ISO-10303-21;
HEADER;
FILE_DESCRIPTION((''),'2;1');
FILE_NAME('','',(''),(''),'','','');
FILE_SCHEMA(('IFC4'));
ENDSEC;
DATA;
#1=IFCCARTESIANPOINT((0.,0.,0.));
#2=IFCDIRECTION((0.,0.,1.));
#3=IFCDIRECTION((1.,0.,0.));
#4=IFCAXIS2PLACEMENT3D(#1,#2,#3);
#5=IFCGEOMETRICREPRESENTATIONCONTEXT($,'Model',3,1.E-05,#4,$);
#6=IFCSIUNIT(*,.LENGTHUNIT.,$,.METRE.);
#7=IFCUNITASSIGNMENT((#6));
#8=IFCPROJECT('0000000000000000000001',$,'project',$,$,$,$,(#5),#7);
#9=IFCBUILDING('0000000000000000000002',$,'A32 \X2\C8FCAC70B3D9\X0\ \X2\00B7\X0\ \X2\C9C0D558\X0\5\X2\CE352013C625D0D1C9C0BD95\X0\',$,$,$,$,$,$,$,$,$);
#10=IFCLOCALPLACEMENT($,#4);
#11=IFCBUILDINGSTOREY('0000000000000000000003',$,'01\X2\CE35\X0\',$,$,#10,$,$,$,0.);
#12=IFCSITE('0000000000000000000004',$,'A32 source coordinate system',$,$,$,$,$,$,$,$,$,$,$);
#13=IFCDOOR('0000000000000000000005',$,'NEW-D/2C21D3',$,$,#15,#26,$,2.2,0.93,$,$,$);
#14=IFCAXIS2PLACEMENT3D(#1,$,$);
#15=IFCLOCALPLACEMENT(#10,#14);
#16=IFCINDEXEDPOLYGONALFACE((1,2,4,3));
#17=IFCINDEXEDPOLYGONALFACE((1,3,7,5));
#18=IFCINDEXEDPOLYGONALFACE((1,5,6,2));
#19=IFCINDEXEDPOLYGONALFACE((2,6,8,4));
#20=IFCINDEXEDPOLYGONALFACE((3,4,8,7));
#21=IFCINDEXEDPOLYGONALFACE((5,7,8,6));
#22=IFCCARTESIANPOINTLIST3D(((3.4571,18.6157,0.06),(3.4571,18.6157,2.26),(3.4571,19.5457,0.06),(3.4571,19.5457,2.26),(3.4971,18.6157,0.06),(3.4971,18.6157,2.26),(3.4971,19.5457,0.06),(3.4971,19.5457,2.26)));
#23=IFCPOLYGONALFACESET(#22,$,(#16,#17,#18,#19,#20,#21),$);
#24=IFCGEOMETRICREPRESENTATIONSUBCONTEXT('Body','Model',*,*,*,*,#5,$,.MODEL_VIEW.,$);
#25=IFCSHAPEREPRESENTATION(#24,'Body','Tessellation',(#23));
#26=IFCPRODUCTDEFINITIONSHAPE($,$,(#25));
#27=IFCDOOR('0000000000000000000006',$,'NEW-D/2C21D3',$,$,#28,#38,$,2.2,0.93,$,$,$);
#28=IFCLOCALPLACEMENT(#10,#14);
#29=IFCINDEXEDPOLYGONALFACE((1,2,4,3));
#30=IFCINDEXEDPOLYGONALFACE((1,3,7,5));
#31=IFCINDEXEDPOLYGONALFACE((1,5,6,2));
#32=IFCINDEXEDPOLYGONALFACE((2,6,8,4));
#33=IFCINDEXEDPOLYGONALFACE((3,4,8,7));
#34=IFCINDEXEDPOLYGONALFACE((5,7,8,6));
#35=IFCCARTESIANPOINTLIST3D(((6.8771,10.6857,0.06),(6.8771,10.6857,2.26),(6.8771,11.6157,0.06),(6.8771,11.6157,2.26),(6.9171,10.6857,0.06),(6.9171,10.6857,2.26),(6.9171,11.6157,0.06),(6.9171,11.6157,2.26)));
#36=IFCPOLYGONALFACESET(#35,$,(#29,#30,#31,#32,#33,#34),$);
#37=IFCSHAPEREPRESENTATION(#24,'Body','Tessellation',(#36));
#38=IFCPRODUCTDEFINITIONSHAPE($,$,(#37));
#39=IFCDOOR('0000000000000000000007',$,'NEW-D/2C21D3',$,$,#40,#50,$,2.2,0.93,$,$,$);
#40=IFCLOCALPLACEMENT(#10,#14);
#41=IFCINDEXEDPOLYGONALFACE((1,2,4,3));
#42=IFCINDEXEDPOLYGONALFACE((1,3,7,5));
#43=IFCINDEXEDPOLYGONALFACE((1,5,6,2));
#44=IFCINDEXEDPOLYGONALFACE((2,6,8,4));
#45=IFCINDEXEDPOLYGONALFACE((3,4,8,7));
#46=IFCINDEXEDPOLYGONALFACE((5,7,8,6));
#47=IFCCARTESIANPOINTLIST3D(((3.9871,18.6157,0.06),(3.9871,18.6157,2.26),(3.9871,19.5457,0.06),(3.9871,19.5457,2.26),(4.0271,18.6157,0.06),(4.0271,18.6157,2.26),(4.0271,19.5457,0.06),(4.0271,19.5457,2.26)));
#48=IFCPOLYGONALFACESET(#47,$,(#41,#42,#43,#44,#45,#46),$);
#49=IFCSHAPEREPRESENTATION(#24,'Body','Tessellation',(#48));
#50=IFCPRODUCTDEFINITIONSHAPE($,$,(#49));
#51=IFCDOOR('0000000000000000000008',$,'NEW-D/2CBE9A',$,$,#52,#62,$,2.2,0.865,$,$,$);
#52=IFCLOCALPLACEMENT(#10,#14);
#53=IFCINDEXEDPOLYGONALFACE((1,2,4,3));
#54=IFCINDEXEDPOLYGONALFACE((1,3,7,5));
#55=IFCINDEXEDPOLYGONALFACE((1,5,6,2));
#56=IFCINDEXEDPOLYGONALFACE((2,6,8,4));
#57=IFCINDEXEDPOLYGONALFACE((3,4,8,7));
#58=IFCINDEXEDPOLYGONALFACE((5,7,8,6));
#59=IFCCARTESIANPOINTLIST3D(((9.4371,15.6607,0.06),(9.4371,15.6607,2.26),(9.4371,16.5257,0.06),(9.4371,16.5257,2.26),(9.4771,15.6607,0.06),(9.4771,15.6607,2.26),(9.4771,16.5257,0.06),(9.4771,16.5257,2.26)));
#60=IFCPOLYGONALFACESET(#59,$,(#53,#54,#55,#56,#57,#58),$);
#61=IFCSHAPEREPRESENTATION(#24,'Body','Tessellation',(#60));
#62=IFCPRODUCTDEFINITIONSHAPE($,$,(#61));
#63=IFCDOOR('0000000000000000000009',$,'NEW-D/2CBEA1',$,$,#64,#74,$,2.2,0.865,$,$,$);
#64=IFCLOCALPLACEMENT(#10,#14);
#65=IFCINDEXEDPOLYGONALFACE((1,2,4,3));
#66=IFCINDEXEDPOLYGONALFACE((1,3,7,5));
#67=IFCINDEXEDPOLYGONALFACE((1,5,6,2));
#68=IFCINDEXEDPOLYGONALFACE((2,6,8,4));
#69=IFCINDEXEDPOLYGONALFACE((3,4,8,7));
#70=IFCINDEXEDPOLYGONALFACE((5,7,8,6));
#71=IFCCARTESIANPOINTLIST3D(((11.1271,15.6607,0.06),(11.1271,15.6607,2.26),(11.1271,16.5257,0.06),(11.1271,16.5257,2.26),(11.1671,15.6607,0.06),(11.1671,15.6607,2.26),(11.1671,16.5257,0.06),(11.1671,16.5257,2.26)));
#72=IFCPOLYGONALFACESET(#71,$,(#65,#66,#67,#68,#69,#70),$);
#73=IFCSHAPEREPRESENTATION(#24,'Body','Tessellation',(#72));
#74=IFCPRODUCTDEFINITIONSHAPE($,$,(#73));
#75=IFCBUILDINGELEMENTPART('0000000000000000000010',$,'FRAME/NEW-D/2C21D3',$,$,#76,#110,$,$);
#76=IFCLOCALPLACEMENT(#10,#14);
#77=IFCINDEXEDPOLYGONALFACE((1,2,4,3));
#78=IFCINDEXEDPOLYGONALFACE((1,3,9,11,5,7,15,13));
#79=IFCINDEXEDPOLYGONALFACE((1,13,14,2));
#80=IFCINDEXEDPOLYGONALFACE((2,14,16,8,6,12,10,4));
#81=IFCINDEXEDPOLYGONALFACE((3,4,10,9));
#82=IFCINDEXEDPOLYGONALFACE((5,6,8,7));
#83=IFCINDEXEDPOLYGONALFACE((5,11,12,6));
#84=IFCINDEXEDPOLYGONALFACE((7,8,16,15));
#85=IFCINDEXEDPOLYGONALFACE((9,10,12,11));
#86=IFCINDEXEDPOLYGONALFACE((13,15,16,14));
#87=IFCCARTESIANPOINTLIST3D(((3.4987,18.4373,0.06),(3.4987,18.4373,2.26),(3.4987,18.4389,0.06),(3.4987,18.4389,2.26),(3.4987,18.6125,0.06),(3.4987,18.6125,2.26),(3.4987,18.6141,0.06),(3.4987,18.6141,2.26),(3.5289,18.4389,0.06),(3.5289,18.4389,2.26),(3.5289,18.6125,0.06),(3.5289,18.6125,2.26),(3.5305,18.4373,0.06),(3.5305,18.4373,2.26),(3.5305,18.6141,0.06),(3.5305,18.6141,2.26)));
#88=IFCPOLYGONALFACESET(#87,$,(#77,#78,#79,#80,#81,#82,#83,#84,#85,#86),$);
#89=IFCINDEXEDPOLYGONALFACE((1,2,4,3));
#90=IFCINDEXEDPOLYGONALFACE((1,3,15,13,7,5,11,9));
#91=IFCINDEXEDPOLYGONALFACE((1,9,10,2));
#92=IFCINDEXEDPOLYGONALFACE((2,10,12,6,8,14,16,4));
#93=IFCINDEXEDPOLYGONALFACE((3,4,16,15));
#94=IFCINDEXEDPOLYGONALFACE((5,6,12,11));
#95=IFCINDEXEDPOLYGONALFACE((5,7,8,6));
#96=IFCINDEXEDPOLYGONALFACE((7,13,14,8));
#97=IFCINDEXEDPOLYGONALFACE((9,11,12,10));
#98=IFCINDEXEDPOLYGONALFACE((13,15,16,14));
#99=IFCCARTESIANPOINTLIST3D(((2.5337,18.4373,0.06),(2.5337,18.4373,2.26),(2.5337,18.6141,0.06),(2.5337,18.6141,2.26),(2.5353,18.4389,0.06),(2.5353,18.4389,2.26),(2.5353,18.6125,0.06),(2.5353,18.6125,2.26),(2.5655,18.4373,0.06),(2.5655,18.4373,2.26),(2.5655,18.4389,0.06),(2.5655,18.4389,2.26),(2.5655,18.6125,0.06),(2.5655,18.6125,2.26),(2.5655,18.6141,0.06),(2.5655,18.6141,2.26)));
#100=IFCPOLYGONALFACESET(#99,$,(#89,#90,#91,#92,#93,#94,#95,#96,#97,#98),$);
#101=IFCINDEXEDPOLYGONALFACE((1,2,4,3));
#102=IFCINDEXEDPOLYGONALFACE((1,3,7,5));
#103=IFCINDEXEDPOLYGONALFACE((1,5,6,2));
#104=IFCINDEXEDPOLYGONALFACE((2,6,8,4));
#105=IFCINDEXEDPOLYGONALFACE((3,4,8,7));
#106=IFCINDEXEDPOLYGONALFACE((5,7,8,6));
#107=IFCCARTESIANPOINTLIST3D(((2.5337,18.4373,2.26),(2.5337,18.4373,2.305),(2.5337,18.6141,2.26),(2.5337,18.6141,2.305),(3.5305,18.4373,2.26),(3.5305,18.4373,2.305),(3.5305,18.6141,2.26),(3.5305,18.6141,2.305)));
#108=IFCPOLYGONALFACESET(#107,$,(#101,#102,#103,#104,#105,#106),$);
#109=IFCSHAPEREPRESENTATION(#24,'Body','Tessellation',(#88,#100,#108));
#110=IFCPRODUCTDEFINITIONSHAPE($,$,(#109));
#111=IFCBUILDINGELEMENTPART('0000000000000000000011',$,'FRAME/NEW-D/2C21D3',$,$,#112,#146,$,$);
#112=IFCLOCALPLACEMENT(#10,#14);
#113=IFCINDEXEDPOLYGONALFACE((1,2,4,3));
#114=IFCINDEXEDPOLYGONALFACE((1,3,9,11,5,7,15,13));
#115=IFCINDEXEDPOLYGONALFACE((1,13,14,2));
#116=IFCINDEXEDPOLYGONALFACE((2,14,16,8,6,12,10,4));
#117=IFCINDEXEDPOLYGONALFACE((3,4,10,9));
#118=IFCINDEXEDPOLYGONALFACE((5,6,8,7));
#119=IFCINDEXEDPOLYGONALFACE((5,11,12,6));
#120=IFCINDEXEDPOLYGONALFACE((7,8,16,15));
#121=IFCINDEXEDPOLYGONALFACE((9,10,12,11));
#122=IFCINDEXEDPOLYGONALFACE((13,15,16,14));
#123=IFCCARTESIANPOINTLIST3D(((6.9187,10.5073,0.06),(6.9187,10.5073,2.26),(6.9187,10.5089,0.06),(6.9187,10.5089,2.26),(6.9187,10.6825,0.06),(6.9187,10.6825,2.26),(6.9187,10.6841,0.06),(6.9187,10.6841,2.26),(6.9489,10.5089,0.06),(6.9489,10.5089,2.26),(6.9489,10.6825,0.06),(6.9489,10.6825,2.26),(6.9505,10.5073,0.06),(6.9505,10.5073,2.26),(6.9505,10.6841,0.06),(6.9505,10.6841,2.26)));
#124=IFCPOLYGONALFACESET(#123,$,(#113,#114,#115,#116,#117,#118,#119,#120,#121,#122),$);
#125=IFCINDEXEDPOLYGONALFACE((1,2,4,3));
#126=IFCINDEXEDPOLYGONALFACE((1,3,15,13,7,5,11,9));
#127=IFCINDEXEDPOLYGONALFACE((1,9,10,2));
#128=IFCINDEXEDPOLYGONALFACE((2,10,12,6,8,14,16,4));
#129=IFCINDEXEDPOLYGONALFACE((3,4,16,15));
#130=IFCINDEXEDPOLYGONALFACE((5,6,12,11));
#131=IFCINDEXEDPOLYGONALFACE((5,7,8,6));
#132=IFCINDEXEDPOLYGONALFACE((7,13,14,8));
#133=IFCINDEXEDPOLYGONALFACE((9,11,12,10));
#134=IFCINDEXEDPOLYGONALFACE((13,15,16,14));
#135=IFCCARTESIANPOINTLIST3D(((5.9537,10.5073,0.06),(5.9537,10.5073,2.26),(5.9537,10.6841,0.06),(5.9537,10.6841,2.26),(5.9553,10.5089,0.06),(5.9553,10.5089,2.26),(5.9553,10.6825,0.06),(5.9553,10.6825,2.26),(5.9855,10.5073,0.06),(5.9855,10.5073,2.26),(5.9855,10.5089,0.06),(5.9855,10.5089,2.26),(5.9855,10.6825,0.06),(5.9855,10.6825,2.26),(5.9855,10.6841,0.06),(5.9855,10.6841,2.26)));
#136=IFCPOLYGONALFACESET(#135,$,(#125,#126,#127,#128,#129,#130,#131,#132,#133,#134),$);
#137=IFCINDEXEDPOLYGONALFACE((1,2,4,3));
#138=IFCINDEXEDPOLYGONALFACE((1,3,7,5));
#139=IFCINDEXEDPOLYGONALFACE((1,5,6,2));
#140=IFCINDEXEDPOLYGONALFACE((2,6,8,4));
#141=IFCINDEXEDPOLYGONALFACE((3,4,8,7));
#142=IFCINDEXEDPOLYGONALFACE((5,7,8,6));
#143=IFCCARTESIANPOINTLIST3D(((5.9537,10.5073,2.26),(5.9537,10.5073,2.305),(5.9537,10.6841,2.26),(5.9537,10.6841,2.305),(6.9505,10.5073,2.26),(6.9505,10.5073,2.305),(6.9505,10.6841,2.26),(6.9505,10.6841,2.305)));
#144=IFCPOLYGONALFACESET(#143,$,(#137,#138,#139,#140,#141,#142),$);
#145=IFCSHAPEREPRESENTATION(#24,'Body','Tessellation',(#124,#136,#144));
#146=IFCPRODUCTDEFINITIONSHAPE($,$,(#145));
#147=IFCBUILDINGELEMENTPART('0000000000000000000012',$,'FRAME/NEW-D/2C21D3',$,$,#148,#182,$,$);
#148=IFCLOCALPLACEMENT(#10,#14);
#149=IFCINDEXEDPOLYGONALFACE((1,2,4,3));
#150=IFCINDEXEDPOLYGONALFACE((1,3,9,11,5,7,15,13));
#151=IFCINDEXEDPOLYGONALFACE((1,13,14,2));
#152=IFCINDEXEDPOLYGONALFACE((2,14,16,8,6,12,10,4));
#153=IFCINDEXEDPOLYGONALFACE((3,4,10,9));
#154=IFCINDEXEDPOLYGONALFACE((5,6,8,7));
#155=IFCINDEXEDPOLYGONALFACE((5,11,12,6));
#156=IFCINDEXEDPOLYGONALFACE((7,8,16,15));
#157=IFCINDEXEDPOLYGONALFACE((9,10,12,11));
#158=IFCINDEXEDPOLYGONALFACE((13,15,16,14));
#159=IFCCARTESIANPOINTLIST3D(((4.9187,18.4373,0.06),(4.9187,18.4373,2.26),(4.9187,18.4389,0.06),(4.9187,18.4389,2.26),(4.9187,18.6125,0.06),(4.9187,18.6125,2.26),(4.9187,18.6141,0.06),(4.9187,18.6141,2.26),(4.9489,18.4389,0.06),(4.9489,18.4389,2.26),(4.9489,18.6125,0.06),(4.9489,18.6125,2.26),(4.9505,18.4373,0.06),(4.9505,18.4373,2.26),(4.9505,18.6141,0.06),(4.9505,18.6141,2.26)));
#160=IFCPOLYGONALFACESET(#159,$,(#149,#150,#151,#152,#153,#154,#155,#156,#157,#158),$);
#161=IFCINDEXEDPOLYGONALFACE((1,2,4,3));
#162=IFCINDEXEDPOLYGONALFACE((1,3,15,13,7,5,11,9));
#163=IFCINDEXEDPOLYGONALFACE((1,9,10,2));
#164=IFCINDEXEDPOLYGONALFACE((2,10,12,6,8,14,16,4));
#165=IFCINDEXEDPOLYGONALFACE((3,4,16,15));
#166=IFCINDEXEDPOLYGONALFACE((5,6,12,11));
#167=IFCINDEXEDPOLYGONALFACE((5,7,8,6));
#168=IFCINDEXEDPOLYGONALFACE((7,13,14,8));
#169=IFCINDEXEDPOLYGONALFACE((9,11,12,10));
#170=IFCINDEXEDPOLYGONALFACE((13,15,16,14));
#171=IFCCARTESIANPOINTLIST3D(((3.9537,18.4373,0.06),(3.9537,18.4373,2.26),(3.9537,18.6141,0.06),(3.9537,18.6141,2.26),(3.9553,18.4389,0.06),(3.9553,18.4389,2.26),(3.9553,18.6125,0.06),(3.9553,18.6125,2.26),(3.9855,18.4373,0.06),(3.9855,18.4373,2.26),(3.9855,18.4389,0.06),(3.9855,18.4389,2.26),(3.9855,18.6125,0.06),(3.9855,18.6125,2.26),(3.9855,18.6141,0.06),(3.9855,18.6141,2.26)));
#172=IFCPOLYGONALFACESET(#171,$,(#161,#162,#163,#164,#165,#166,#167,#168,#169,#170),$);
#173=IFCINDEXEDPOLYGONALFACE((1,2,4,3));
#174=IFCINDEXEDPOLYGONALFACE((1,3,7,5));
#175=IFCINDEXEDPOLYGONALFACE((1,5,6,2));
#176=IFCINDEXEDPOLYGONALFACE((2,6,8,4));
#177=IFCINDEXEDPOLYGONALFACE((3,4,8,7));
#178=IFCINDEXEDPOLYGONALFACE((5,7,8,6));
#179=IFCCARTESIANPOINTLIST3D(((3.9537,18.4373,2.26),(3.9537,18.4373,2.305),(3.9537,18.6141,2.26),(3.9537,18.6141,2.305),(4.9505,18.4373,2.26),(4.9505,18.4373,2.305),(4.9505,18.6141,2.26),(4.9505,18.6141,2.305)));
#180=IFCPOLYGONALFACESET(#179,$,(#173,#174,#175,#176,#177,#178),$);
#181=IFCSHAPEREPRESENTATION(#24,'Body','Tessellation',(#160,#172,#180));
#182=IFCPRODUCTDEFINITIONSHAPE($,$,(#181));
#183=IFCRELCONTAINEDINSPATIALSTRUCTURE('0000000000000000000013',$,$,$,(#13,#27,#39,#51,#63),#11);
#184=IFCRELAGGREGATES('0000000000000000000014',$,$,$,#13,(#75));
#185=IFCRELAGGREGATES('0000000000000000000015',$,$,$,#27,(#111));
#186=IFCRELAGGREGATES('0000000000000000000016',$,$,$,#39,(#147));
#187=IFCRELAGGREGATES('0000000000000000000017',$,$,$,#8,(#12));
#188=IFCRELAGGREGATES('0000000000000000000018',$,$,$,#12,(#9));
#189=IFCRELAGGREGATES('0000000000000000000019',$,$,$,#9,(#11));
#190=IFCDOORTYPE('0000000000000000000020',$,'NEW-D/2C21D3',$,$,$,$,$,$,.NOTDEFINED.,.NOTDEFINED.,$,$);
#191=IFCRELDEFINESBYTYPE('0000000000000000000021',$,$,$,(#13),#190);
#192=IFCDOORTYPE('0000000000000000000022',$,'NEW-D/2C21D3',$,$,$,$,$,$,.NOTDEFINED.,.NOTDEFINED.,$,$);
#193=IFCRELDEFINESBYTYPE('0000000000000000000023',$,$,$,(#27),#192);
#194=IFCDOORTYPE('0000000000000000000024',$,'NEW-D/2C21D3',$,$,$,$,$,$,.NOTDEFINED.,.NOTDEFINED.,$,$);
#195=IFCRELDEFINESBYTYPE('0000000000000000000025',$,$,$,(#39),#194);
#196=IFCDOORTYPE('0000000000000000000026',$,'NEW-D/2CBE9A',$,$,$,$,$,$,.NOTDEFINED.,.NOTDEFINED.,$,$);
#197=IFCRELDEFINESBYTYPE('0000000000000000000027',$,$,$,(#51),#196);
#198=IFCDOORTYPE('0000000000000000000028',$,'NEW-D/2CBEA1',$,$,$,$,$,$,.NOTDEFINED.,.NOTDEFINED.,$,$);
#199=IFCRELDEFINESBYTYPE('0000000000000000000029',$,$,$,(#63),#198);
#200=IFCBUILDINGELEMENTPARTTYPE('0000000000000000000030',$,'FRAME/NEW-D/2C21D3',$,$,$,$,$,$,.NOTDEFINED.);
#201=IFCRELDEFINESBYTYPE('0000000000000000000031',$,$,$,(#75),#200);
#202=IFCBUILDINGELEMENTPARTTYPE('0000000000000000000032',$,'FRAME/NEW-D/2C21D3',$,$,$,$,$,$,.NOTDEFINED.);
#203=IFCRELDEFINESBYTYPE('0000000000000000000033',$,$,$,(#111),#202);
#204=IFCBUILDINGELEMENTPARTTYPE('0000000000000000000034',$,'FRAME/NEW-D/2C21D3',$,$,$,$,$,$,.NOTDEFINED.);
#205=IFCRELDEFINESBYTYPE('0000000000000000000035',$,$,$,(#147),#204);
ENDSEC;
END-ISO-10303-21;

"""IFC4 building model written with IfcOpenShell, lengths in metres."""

from ifc_helpers import new_model, si_unit, frame, origin, origin_with_axes, place, context, subcontext, project, spatial, polyline, outline, extrude, source, transform, mapped, type_object, type_shapes, element, aggregate, save


model = new_model("IFC4")

# Units and contexts
model_context = context("Model", 3, precision=1e-05, world=origin_with_axes())
body_context = subcontext(model_context, "Body", "Model", "MODEL_VIEW")
ifc_project = project(units=[si_unit("LENGTHUNIT", "METRE")], contexts=[model_context])

# Site, building, storey
site = spatial("IfcSite", under=ifc_project, Name="A32 source coordinate system")
building = spatial("IfcBuilding", under=site, Name="A32 주거동 · 지하5층–옥탑지붕")
storey_placement = place(None, origin_with_axes())
storey = spatial("IfcBuildingStorey", under=building, at=storey_placement, Name="01층", Elevation=0.0)

# Doors
door_type_1 = type_object("IfcDoorType", Name="NEW-D/2C21D3", OperationType="NOTDEFINED", PredefinedType="NOTDEFINED")
shared_shape_1 = source(origin(), body_context, "Body", "SweptSolid", [
    extrude(outline(polyline([(3.4971, 18.6157), (3.4571, 18.6157), (3.4571, 19.5457), (3.4971, 19.5457), (3.4971, 18.6157)])), frame((0.0, 0.0, 0.06)), (0.0, 0.0, 1.0), 2.2),
])
type_shapes(door_type_1, [shared_shape_1])
door_1_placement = place(storey_placement, origin_with_axes())
door_1 = element("IfcDoor", 1, at=door_1_placement, inside=storey, type_object=door_type_1, Name="NEW-D/2C21D3", OverallHeight=2.2, OverallWidth=0.93, context=body_context, shape_type="MappedRepresentation", body=[
    mapped(shared_shape_1, transform((0.0, 0.0, 0.0), scale=1.0)),
])
door_type_2 = type_object("IfcDoorType", Name="NEW-D/2C21D3", OperationType="NOTDEFINED", PredefinedType="NOTDEFINED")
shared_shape_2 = source(origin(), body_context, "Body", "SweptSolid", [
    extrude(outline(polyline([(6.9171, 10.6857), (6.8771, 10.6857), (6.8771, 11.6157), (6.9171, 11.6157), (6.9171, 10.6857)])), frame((0.0, 0.0, 0.06)), (0.0, 0.0, 1.0), 2.2),
])
type_shapes(door_type_2, [shared_shape_2])
door_2_placement = place(storey_placement, origin_with_axes())
door_2 = element("IfcDoor", 2, at=door_2_placement, inside=storey, type_object=door_type_2, Name="NEW-D/2C21D3", OverallHeight=2.2, OverallWidth=0.93, context=body_context, shape_type="MappedRepresentation", body=[
    mapped(shared_shape_2, transform((0.0, 0.0, 0.0), scale=1.0)),
])
door_type_3 = type_object("IfcDoorType", Name="NEW-D/2C21D3", OperationType="NOTDEFINED", PredefinedType="NOTDEFINED")
shared_shape_3 = source(origin(), body_context, "Body", "SweptSolid", [
    extrude(outline(polyline([(4.0271, 19.5457), (4.0271, 18.6157), (3.9871, 18.6157), (3.9871, 19.5457), (4.0271, 19.5457)])), frame((0.0, 0.0, 0.06)), (0.0, 0.0, 1.0), 2.2),
])
type_shapes(door_type_3, [shared_shape_3])
door_3_placement = place(storey_placement, origin_with_axes())
door_3 = element("IfcDoor", 3, at=door_3_placement, inside=storey, type_object=door_type_3, Name="NEW-D/2C21D3", OverallHeight=2.2, OverallWidth=0.93, context=body_context, shape_type="MappedRepresentation", body=[
    mapped(shared_shape_3, transform((0.0, 0.0, 0.0), scale=1.0)),
])

# Doors
door_type_4 = type_object("IfcDoorType", Name="NEW-D/2CBE9A", OperationType="NOTDEFINED", PredefinedType="NOTDEFINED")
shared_shape_4 = source(origin(), body_context, "Body", "SweptSolid", [
    extrude(outline(polyline([(9.4371, 15.6607), (9.4371, 16.5257), (9.4771, 16.5257), (9.4771, 15.6607), (9.4371, 15.6607)])), frame((0.0, 0.0, 0.06)), (0.0, 0.0, 1.0), 2.2),
])
type_shapes(door_type_4, [shared_shape_4])
door_4_placement = place(storey_placement, origin_with_axes())
element("IfcDoor", 4, at=door_4_placement, inside=storey, type_object=door_type_4, Name="NEW-D/2CBE9A", OverallHeight=2.2, OverallWidth=0.865, context=body_context, shape_type="MappedRepresentation", body=[
    mapped(shared_shape_4, transform((0.0, 0.0, 0.0), scale=1.0)),
])
door_type_5 = type_object("IfcDoorType", Name="NEW-D/2CBEA1", OperationType="NOTDEFINED", PredefinedType="NOTDEFINED")
shared_shape_5 = source(origin(), body_context, "Body", "SweptSolid", [
    extrude(outline(polyline([(11.1271, 16.5257), (11.1671, 16.5257), (11.1671, 15.6607), (11.1271, 15.6607), (11.1271, 16.5257)])), frame((0.0, 0.0, 0.06)), (0.0, 0.0, 1.0), 2.2),
])
type_shapes(door_type_5, [shared_shape_5])
door_5_placement = place(storey_placement, origin_with_axes())
element("IfcDoor", 5, at=door_5_placement, inside=storey, type_object=door_type_5, Name="NEW-D/2CBEA1", OverallHeight=2.2, OverallWidth=0.865, context=body_context, shape_type="MappedRepresentation", body=[
    mapped(shared_shape_5, transform((0.0, 0.0, 0.0), scale=1.0)),
])

# Building element parts
building_element_part_type_1 = type_object("IfcBuildingElementPartType", Name="FRAME/NEW-D/2C21D3", PredefinedType="NOTDEFINED")
shared_shape_6 = source(origin(), body_context, "Body", "SweptSolid", [
    extrude(outline(polyline([(3.5305, 18.4373), (3.4987, 18.4373), (3.4987, 18.4389), (3.5289, 18.4389), (3.5289, 18.6125), (3.4987, 18.6125), (3.4987, 18.6141), (3.5305, 18.6141), (3.5305, 18.4373)])), frame((0.0, 0.0, 0.06)), (0.0, 0.0, 1.0), 2.2),
    extrude(outline(polyline([(2.5353, 18.6125), (2.5353, 18.4389), (2.5655, 18.4389), (2.5655, 18.4373), (2.5337, 18.4373), (2.5337, 18.6141), (2.5655, 18.6141), (2.5655, 18.6125), (2.5353, 18.6125)])), frame((0.0, 0.0, 0.06)), (0.0, 0.0, 1.0), 2.2),
    extrude(outline(polyline([(3.5305, 18.4373), (3.5305, 18.6141), (2.5337, 18.6141), (2.5337, 18.4373), (3.5305, 18.4373)])), frame((0.0, 0.0, 2.26)), (0.0, 0.0, 1.0), 0.045),
])
type_shapes(building_element_part_type_1, [shared_shape_6])
building_element_part_1_placement = place(door_1_placement, origin_with_axes())
building_element_part_1 = element("IfcBuildingElementPart", 6, at=building_element_part_1_placement, type_object=building_element_part_type_1, Name="FRAME/NEW-D/2C21D3", context=body_context, shape_type="MappedRepresentation", body=[
    mapped(shared_shape_6, transform((0.0, 0.0, 0.0), scale=1.0)),
])
aggregate(door_1, [building_element_part_1])
building_element_part_type_2 = type_object("IfcBuildingElementPartType", Name="FRAME/NEW-D/2C21D3", PredefinedType="NOTDEFINED")
shared_shape_7 = source(origin(), body_context, "Body", "SweptSolid", [
    extrude(outline(polyline([(6.9505, 10.5073), (6.9187, 10.5073), (6.9187, 10.5089), (6.9489, 10.5089), (6.9489, 10.6825), (6.9187, 10.6825), (6.9187, 10.6841), (6.9505, 10.6841), (6.9505, 10.5073)])), frame((0.0, 0.0, 0.06)), (0.0, 0.0, 1.0), 2.2),
    extrude(outline(polyline([(5.9553, 10.6825), (5.9553, 10.5089), (5.9855, 10.5089), (5.9855, 10.5073), (5.9537, 10.5073), (5.9537, 10.6841), (5.9855, 10.6841), (5.9855, 10.6825), (5.9553, 10.6825)])), frame((0.0, 0.0, 0.06)), (0.0, 0.0, 1.0), 2.2),
    extrude(outline(polyline([(6.9505, 10.5073), (6.9505, 10.6841), (5.9537, 10.6841), (5.9537, 10.5073), (6.9505, 10.5073)])), frame((0.0, 0.0, 2.26)), (0.0, 0.0, 1.0), 0.045),
])
type_shapes(building_element_part_type_2, [shared_shape_7])
building_element_part_2_placement = place(door_2_placement, origin_with_axes())
building_element_part_2 = element("IfcBuildingElementPart", 7, at=building_element_part_2_placement, type_object=building_element_part_type_2, Name="FRAME/NEW-D/2C21D3", context=body_context, shape_type="MappedRepresentation", body=[
    mapped(shared_shape_7, transform((0.0, 0.0, 0.0), scale=1.0)),
])
aggregate(door_2, [building_element_part_2])
building_element_part_type_3 = type_object("IfcBuildingElementPartType", Name="FRAME/NEW-D/2C21D3", PredefinedType="NOTDEFINED")
shared_shape_8 = source(origin(), body_context, "Body", "SweptSolid", [
    extrude(outline(polyline([(4.9505, 18.4373), (4.9187, 18.4373), (4.9187, 18.4389), (4.9489, 18.4389), (4.9489, 18.6125), (4.9187, 18.6125), (4.9187, 18.6141), (4.9505, 18.6141), (4.9505, 18.4373)])), frame((0.0, 0.0, 0.06)), (0.0, 0.0, 1.0), 2.2),
    extrude(outline(polyline([(3.9553, 18.6125), (3.9553, 18.4389), (3.9855, 18.4389), (3.9855, 18.4373), (3.9537, 18.4373), (3.9537, 18.6141), (3.9855, 18.6141), (3.9855, 18.6125), (3.9553, 18.6125)])), frame((0.0, 0.0, 0.06)), (0.0, 0.0, 1.0), 2.2),
    extrude(outline(polyline([(4.9505, 18.4373), (4.9505, 18.6141), (3.9537, 18.6141), (3.9537, 18.4373), (4.9505, 18.4373)])), frame((0.0, 0.0, 2.26)), (0.0, 0.0, 1.0), 0.045),
])
type_shapes(building_element_part_type_3, [shared_shape_8])
building_element_part_3_placement = place(door_3_placement, origin_with_axes())
building_element_part_3 = element("IfcBuildingElementPart", 8, at=building_element_part_3_placement, type_object=building_element_part_type_3, Name="FRAME/NEW-D/2C21D3", context=body_context, shape_type="MappedRepresentation", body=[
    mapped(shared_shape_8, transform((0.0, 0.0, 0.0), scale=1.0)),
])
aggregate(door_3, [building_element_part_3])

save(model, "model.ifc")
